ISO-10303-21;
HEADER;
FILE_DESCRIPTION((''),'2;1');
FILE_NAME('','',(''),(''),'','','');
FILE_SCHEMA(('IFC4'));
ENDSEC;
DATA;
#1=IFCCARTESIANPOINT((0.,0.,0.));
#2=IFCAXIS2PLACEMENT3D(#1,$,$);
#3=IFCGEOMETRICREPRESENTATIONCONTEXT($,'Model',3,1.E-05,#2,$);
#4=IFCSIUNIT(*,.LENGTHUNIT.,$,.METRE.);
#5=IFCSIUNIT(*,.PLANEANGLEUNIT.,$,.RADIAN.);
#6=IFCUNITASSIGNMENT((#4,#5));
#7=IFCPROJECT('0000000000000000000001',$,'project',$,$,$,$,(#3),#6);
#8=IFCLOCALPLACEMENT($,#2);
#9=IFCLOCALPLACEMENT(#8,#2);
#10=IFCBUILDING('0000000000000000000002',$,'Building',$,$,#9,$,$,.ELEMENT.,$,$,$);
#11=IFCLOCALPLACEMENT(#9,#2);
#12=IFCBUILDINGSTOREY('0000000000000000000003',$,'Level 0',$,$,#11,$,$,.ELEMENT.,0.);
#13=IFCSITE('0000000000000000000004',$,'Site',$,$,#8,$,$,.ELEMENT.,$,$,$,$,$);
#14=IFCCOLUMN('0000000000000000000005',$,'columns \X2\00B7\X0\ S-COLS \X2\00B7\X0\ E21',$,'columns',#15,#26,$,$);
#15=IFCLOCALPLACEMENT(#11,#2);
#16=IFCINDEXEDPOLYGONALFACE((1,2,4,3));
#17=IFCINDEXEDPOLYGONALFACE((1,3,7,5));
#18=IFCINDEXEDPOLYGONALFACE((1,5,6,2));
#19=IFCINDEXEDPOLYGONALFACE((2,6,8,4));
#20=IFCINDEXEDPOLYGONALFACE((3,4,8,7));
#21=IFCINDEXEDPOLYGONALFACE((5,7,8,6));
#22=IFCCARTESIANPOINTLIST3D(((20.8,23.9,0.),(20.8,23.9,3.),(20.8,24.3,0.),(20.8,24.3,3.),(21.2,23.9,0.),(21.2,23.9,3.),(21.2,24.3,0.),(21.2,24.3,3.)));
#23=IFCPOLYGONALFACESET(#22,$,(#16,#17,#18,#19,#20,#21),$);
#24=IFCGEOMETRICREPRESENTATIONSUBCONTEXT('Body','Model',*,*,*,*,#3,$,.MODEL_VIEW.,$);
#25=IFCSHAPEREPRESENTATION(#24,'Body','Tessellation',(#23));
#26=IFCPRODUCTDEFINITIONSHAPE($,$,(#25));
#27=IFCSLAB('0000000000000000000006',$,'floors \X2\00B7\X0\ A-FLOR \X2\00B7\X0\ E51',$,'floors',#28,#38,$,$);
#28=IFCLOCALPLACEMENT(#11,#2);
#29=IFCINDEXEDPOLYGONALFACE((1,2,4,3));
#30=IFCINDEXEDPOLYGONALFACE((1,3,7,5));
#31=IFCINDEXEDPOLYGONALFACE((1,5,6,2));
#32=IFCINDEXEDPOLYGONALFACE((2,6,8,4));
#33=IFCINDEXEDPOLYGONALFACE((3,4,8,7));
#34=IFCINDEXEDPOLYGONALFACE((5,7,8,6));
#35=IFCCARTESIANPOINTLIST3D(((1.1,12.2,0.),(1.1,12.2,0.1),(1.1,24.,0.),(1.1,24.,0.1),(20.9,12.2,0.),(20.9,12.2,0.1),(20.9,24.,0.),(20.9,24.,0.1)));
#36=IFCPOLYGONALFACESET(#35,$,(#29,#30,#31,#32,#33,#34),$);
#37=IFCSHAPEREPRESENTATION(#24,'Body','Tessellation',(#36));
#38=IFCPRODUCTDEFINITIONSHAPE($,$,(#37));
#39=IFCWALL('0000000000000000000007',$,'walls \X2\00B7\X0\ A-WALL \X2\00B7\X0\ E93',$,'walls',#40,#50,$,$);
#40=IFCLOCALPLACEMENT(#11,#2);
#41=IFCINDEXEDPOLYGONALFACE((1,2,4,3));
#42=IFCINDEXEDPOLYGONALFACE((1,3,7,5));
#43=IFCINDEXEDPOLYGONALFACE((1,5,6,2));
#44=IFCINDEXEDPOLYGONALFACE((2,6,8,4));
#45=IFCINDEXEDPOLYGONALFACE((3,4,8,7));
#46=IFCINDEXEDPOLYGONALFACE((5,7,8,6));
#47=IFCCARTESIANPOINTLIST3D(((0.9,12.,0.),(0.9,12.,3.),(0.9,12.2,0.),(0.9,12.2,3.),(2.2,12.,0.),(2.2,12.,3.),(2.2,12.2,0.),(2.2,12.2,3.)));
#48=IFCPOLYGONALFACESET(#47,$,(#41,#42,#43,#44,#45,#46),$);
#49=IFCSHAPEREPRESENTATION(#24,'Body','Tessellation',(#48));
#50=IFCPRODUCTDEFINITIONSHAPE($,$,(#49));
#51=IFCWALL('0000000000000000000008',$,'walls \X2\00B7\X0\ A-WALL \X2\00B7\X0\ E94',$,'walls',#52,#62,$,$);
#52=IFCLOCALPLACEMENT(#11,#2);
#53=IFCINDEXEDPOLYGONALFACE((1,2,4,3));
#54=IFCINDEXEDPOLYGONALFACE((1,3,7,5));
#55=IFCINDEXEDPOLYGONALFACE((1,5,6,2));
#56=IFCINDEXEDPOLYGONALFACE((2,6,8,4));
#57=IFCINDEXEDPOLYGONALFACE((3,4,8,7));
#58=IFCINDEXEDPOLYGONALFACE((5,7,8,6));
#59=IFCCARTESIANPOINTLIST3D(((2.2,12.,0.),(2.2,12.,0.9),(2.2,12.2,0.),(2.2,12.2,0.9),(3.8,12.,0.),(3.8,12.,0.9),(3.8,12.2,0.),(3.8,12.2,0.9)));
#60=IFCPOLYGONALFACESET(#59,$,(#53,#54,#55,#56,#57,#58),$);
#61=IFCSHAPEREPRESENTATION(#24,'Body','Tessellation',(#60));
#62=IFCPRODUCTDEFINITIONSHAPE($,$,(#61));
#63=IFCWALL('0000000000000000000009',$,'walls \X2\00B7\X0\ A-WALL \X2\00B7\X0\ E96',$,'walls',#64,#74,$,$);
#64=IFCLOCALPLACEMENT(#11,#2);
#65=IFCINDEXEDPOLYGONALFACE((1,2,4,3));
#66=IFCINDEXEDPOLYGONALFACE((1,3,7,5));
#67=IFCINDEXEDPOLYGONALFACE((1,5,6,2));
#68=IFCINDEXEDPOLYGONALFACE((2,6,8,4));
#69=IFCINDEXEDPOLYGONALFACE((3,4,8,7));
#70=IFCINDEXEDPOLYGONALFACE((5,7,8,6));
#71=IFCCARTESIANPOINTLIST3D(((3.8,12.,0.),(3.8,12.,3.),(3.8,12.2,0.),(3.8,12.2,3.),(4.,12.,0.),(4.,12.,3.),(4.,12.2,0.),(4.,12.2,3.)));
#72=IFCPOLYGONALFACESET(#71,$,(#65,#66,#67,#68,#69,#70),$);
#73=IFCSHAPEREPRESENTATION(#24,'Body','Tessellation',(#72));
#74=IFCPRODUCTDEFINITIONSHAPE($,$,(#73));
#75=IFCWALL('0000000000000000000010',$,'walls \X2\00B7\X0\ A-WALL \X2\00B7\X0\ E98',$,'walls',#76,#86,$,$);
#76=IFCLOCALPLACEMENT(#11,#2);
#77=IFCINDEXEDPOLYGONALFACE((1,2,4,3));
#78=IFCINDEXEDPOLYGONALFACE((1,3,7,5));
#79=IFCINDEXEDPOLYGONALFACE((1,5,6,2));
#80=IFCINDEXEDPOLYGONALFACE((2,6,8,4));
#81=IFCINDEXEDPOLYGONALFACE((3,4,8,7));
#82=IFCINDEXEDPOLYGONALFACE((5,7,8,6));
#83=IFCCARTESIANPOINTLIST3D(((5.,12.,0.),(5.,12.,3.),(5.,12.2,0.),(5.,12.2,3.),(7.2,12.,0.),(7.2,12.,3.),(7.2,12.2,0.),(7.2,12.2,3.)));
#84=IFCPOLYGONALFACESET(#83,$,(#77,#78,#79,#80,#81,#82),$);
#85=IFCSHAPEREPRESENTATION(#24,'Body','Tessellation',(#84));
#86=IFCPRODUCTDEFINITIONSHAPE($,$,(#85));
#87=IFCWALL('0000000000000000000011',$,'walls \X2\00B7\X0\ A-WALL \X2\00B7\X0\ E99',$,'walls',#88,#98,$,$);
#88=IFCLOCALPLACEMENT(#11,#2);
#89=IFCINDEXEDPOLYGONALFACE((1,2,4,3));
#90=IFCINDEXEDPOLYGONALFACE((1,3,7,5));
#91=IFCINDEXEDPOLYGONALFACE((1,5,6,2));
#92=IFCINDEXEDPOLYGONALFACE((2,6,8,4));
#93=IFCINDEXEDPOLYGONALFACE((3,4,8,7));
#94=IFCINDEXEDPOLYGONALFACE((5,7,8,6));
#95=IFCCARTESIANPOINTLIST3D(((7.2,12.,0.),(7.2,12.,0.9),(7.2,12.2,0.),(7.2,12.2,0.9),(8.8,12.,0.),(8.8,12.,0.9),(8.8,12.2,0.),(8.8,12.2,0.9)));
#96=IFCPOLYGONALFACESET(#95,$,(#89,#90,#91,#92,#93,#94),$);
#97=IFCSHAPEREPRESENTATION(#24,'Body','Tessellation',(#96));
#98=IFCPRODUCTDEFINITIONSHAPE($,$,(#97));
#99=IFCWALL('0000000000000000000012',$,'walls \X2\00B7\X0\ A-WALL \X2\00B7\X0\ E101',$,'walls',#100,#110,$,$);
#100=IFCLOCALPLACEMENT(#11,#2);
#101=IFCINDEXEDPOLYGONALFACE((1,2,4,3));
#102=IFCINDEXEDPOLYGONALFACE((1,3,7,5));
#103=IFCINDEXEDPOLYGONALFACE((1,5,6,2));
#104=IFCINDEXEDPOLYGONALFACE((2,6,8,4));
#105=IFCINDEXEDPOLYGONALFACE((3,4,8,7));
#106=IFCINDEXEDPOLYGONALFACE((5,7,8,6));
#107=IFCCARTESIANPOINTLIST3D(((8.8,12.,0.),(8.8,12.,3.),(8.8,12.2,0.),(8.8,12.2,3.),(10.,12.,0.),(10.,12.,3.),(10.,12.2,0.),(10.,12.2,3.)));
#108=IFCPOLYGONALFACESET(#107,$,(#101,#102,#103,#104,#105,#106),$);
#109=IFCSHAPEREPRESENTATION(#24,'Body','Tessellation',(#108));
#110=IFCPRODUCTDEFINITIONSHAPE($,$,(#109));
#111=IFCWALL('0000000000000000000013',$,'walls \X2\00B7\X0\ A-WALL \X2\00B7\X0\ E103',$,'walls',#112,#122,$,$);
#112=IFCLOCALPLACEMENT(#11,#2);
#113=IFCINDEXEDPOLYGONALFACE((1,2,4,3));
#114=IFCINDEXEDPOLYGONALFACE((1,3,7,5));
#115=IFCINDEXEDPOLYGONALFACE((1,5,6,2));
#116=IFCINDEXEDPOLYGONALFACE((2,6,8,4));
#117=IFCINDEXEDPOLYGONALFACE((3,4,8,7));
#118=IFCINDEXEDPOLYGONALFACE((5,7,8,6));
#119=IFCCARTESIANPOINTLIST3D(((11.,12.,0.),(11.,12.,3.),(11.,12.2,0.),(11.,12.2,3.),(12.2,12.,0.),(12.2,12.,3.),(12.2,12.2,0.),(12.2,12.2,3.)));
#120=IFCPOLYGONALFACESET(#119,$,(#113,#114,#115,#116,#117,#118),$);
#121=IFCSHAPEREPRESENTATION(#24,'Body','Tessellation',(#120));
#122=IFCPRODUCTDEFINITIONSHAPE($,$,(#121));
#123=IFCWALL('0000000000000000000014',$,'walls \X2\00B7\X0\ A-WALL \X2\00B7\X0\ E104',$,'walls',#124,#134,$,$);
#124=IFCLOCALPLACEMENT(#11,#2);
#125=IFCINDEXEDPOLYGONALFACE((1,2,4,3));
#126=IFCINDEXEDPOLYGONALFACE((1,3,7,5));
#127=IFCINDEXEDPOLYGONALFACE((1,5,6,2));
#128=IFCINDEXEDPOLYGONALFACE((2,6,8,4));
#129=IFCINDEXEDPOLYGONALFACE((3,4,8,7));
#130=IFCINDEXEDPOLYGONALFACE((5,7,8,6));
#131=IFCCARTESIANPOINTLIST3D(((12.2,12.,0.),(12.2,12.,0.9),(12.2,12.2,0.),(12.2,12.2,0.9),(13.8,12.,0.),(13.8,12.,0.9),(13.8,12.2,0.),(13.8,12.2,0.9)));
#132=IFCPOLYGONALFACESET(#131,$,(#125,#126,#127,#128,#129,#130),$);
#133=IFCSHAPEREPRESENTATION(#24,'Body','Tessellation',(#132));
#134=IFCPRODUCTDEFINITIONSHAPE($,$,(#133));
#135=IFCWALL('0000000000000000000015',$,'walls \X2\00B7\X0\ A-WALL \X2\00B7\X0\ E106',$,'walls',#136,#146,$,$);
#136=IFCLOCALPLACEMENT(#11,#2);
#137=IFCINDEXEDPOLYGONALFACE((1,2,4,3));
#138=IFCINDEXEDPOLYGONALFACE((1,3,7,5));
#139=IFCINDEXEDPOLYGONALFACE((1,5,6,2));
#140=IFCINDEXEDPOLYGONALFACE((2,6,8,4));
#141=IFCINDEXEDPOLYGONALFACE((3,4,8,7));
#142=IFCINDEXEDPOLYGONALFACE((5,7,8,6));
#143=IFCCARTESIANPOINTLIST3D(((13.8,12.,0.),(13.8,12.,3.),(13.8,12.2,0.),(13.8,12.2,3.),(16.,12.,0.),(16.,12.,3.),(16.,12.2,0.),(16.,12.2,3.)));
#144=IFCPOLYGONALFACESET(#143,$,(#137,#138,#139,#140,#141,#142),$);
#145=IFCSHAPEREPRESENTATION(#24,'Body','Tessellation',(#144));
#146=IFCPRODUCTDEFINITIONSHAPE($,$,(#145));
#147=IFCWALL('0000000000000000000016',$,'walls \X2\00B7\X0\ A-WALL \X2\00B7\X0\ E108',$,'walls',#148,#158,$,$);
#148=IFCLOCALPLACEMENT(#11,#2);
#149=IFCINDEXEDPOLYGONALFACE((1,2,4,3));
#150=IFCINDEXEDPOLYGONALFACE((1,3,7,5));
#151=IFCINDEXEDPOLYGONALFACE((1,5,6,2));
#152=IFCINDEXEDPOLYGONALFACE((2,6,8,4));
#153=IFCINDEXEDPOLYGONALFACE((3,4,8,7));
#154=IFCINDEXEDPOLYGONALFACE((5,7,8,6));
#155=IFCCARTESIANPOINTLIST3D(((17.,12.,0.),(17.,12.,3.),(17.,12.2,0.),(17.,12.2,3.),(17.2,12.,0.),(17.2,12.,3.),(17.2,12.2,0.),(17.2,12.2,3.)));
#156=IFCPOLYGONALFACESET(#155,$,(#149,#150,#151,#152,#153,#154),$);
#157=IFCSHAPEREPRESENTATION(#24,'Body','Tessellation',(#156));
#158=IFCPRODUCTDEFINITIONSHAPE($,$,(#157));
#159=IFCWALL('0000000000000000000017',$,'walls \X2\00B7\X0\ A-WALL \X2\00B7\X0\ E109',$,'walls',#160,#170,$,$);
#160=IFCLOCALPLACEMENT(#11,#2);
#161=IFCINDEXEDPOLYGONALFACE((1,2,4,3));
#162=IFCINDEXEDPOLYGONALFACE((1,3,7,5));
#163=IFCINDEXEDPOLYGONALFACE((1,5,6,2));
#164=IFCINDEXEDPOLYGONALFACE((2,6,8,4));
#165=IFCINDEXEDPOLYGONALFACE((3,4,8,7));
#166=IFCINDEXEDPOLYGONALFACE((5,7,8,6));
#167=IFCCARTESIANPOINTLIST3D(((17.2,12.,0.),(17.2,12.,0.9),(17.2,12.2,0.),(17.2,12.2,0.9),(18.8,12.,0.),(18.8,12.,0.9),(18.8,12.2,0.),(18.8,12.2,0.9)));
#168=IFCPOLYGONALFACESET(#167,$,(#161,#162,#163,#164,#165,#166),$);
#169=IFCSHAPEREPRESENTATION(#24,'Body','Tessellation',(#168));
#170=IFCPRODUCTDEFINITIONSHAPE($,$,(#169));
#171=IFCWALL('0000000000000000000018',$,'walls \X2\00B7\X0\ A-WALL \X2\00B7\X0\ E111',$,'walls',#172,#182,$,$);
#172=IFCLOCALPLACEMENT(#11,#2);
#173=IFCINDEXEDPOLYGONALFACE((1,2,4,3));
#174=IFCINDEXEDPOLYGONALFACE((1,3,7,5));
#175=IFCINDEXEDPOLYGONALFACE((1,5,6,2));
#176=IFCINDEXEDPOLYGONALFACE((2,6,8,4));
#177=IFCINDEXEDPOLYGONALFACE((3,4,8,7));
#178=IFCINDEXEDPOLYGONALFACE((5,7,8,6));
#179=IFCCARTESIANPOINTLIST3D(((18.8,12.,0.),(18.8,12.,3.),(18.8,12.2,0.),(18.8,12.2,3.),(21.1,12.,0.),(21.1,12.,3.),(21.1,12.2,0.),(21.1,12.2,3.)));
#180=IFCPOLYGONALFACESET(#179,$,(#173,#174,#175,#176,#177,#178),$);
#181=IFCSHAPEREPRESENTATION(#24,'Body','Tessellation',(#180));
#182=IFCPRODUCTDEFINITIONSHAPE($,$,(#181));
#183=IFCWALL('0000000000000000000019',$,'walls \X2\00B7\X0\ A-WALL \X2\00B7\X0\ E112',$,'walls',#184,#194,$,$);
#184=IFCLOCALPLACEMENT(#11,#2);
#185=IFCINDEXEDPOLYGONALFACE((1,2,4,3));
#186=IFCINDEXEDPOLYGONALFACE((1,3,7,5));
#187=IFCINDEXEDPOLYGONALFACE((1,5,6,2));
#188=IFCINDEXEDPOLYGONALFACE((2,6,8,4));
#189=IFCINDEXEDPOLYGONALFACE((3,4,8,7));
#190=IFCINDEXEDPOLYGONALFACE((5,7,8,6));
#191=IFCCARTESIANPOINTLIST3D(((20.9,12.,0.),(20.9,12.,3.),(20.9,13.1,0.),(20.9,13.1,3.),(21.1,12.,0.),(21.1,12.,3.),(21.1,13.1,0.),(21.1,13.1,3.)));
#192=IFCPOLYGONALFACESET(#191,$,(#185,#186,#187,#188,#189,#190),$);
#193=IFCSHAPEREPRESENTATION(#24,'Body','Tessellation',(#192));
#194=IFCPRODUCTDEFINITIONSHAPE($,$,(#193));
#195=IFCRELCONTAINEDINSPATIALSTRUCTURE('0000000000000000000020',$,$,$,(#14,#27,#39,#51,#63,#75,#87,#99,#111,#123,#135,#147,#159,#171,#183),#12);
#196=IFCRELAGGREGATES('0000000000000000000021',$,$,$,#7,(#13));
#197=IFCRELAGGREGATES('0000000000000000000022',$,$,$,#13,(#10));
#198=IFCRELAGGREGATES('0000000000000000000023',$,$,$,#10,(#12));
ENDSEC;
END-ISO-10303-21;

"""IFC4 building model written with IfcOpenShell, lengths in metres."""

from ifc_helpers import new_model, si_unit, frame, origin, place, context, subcontext, project, spatial, polyline, outline, extrude, element, save


model = new_model("IFC4")

# Units and contexts
model_context = context("Model", 3, precision=1e-05, world=origin())
body_context = subcontext(model_context, "Body", "Model", "MODEL_VIEW")
ifc_project = project(units=[si_unit("LENGTHUNIT", "METRE"), si_unit("PLANEANGLEUNIT", "RADIAN")], contexts=[model_context])

# Site, building, storey
site_placement = place(None, origin())
site = spatial("IfcSite", under=ifc_project, at=site_placement, Name="Site", CompositionType="ELEMENT")
building_placement = place(site_placement, origin())
building = spatial("IfcBuilding", under=site, at=building_placement, Name="Building", CompositionType="ELEMENT")
storey_placement = place(building_placement, origin())
storey = spatial("IfcBuildingStorey", under=building, at=storey_placement, Name="Level 0", CompositionType="ELEMENT", Elevation=0.0)

# Column
column_placement = place(storey_placement, origin())
element("IfcColumn", 1, at=column_placement, inside=storey, Name="columns · S-COLS · E21", ObjectType="columns", context=body_context, shape_type="SweptSolid", body=[
    extrude(outline(polyline([(20.8, 23.9), (21.2, 23.9), (21.2, 24.3), (20.8, 24.3), (20.8, 23.9)])), origin(), (0.0, 0.0, 1.0), 3.0),
])

# Slab
slab_placement = place(storey_placement, origin())
element("IfcSlab", 2, at=slab_placement, inside=storey, Name="floors · A-FLOR · E51", ObjectType="floors", context=body_context, shape_type="SweptSolid", body=[
    extrude(outline(polyline([(1.1, 12.2), (20.9, 12.2), (20.9, 24.0), (1.1, 24.0), (1.1, 12.2)])), origin(), (0.0, 0.0, 1.0), 0.1),
])

# Wall
wall_1_placement = place(storey_placement, origin())
element("IfcWall", 3, at=wall_1_placement, inside=storey, Name="walls · A-WALL · E93", ObjectType="walls", context=body_context, shape_type="SweptSolid", body=[
    extrude(outline(polyline([(0.9, 12.0), (2.2, 12.0), (2.2, 12.2), (0.9, 12.2), (0.9, 12.0)])), origin(), (0.0, 0.0, 1.0), 3.0),
])

# Wall, opening
wall_2_placement = place(storey_placement, origin())
wall_2 = element("IfcWall", 4, at=wall_2_placement, inside=storey, Name="walls · A-WALL · E94", ObjectType="walls", context=body_context, shape_type="SweptSolid", body=[
    extrude(outline(polyline([(2.2, 12.0), (3.8, 12.0), (3.8, 12.2), (2.2, 12.2), (2.2, 12.0)])), origin(), (0.0, 0.0, 1.0), 0.9),
])
opening_1_placement = place(storey_placement, frame((0.0, 0.0, 0.9)))
element("IfcOpeningElement", 5, at=opening_1_placement, cuts=wall_2, ObjectType="Opening", context=body_context, shape_type="SweptSolid", body=[
    extrude(outline(polyline([(2.2, 12.0), (3.8, 12.0), (3.8, 12.2), (2.2, 12.2), (2.2, 12.0)])), origin(), (0.0, 0.0, 1.0), 1.4),
])

# Walls
wall_3_placement = place(storey_placement, origin())
element("IfcWall", 6, at=wall_3_placement, inside=storey, Name="walls · A-WALL · E96", ObjectType="walls", context=body_context, shape_type="SweptSolid", body=[
    extrude(outline(polyline([(3.8, 12.0), (4.0, 12.0), (4.0, 12.2), (3.8, 12.2), (3.8, 12.0)])), origin(), (0.0, 0.0, 1.0), 3.0),
])
wall_4_placement = place(storey_placement, origin())
element("IfcWall", 7, at=wall_4_placement, inside=storey, Name="walls · A-WALL · E98", ObjectType="walls", context=body_context, shape_type="SweptSolid", body=[
    extrude(outline(polyline([(5.0, 12.0), (7.2, 12.0), (7.2, 12.2), (5.0, 12.2), (5.0, 12.0)])), origin(), (0.0, 0.0, 1.0), 3.0),
])

# Wall, opening
wall_5_placement = place(storey_placement, origin())
wall_5 = element("IfcWall", 8, at=wall_5_placement, inside=storey, Name="walls · A-WALL · E99", ObjectType="walls", context=body_context, shape_type="SweptSolid", body=[
    extrude(outline(polyline([(7.2, 12.0), (8.8, 12.0), (8.8, 12.2), (7.2, 12.2), (7.2, 12.0)])), origin(), (0.0, 0.0, 1.0), 0.9),
])
opening_2_placement = place(storey_placement, frame((0.0, 0.0, 0.9)))
element("IfcOpeningElement", 9, at=opening_2_placement, cuts=wall_5, ObjectType="Opening", context=body_context, shape_type="SweptSolid", body=[
    extrude(outline(polyline([(7.2, 12.0), (8.8, 12.0), (8.8, 12.2), (7.2, 12.2), (7.2, 12.0)])), origin(), (0.0, 0.0, 1.0), 1.4),
])

# Walls
wall_6_placement = place(storey_placement, origin())
element("IfcWall", 10, at=wall_6_placement, inside=storey, Name="walls · A-WALL · E101", ObjectType="walls", context=body_context, shape_type="SweptSolid", body=[
    extrude(outline(polyline([(8.8, 12.0), (10.0, 12.0), (10.0, 12.2), (8.8, 12.2), (8.8, 12.0)])), origin(), (0.0, 0.0, 1.0), 3.0),
])
wall_7_placement = place(storey_placement, origin())
element("IfcWall", 11, at=wall_7_placement, inside=storey, Name="walls · A-WALL · E103", ObjectType="walls", context=body_context, shape_type="SweptSolid", body=[
    extrude(outline(polyline([(11.0, 12.0), (12.2, 12.0), (12.2, 12.2), (11.0, 12.2), (11.0, 12.0)])), origin(), (0.0, 0.0, 1.0), 3.0),
])

# Wall, opening
wall_8_placement = place(storey_placement, origin())
wall_8 = element("IfcWall", 12, at=wall_8_placement, inside=storey, Name="walls · A-WALL · E104", ObjectType="walls", context=body_context, shape_type="SweptSolid", body=[
    extrude(outline(polyline([(12.2, 12.0), (13.8, 12.0), (13.8, 12.2), (12.2, 12.2), (12.2, 12.0)])), origin(), (0.0, 0.0, 1.0), 0.9),
])
opening_3_placement = place(storey_placement, frame((0.0, 0.0, 0.9)))
element("IfcOpeningElement", 13, at=opening_3_placement, cuts=wall_8, ObjectType="Opening", context=body_context, shape_type="SweptSolid", body=[
    extrude(outline(polyline([(12.2, 12.0), (13.8, 12.0), (13.8, 12.2), (12.2, 12.2), (12.2, 12.0)])), origin(), (0.0, 0.0, 1.0), 1.4),
])

# Walls
wall_9_placement = place(storey_placement, origin())
element("IfcWall", 14, at=wall_9_placement, inside=storey, Name="walls · A-WALL · E106", ObjectType="walls", context=body_context, shape_type="SweptSolid", body=[
    extrude(outline(polyline([(13.8, 12.0), (16.0, 12.0), (16.0, 12.2), (13.8, 12.2), (13.8, 12.0)])), origin(), (0.0, 0.0, 1.0), 3.0),
])
wall_10_placement = place(storey_placement, origin())
element("IfcWall", 15, at=wall_10_placement, inside=storey, Name="walls · A-WALL · E108", ObjectType="walls", context=body_context, shape_type="SweptSolid", body=[
    extrude(outline(polyline([(17.0, 12.0), (17.2, 12.0), (17.2, 12.2), (17.0, 12.2), (17.0, 12.0)])), origin(), (0.0, 0.0, 1.0), 3.0),
])

# Wall, opening
wall_11_placement = place(storey_placement, origin())
wall_11 = element("IfcWall", 16, at=wall_11_placement, inside=storey, Name="walls · A-WALL · E109", ObjectType="walls", context=body_context, shape_type="SweptSolid", body=[
    extrude(outline(polyline([(17.2, 12.0), (18.8, 12.0), (18.8, 12.2), (17.2, 12.2), (17.2, 12.0)])), origin(), (0.0, 0.0, 1.0), 0.9),
])
opening_4_placement = place(storey_placement, frame((0.0, 0.0, 0.9)))
element("IfcOpeningElement", 17, at=opening_4_placement, cuts=wall_11, ObjectType="Opening", context=body_context, shape_type="SweptSolid", body=[
    extrude(outline(polyline([(17.2, 12.0), (18.8, 12.0), (18.8, 12.2), (17.2, 12.2), (17.2, 12.0)])), origin(), (0.0, 0.0, 1.0), 1.4),
])

# Walls
wall_12_placement = place(storey_placement, origin())
element("IfcWall", 18, at=wall_12_placement, inside=storey, Name="walls · A-WALL · E111", ObjectType="walls", context=body_context, shape_type="SweptSolid", body=[
    extrude(outline(polyline([(18.8, 12.0), (21.1, 12.0), (21.1, 12.2), (18.8, 12.2), (18.8, 12.0)])), origin(), (0.0, 0.0, 1.0), 3.0),
])
wall_13_placement = place(storey_placement, origin())
element("IfcWall", 19, at=wall_13_placement, inside=storey, Name="walls · A-WALL · E112", ObjectType="walls", context=body_context, shape_type="SweptSolid", body=[
    extrude(outline(polyline([(21.1, 12.0), (21.1, 13.1), (20.9, 13.1), (20.9, 12.0), (21.1, 12.0)])), origin(), (0.0, 0.0, 1.0), 3.0),
])

save(model, "model.ifc")
